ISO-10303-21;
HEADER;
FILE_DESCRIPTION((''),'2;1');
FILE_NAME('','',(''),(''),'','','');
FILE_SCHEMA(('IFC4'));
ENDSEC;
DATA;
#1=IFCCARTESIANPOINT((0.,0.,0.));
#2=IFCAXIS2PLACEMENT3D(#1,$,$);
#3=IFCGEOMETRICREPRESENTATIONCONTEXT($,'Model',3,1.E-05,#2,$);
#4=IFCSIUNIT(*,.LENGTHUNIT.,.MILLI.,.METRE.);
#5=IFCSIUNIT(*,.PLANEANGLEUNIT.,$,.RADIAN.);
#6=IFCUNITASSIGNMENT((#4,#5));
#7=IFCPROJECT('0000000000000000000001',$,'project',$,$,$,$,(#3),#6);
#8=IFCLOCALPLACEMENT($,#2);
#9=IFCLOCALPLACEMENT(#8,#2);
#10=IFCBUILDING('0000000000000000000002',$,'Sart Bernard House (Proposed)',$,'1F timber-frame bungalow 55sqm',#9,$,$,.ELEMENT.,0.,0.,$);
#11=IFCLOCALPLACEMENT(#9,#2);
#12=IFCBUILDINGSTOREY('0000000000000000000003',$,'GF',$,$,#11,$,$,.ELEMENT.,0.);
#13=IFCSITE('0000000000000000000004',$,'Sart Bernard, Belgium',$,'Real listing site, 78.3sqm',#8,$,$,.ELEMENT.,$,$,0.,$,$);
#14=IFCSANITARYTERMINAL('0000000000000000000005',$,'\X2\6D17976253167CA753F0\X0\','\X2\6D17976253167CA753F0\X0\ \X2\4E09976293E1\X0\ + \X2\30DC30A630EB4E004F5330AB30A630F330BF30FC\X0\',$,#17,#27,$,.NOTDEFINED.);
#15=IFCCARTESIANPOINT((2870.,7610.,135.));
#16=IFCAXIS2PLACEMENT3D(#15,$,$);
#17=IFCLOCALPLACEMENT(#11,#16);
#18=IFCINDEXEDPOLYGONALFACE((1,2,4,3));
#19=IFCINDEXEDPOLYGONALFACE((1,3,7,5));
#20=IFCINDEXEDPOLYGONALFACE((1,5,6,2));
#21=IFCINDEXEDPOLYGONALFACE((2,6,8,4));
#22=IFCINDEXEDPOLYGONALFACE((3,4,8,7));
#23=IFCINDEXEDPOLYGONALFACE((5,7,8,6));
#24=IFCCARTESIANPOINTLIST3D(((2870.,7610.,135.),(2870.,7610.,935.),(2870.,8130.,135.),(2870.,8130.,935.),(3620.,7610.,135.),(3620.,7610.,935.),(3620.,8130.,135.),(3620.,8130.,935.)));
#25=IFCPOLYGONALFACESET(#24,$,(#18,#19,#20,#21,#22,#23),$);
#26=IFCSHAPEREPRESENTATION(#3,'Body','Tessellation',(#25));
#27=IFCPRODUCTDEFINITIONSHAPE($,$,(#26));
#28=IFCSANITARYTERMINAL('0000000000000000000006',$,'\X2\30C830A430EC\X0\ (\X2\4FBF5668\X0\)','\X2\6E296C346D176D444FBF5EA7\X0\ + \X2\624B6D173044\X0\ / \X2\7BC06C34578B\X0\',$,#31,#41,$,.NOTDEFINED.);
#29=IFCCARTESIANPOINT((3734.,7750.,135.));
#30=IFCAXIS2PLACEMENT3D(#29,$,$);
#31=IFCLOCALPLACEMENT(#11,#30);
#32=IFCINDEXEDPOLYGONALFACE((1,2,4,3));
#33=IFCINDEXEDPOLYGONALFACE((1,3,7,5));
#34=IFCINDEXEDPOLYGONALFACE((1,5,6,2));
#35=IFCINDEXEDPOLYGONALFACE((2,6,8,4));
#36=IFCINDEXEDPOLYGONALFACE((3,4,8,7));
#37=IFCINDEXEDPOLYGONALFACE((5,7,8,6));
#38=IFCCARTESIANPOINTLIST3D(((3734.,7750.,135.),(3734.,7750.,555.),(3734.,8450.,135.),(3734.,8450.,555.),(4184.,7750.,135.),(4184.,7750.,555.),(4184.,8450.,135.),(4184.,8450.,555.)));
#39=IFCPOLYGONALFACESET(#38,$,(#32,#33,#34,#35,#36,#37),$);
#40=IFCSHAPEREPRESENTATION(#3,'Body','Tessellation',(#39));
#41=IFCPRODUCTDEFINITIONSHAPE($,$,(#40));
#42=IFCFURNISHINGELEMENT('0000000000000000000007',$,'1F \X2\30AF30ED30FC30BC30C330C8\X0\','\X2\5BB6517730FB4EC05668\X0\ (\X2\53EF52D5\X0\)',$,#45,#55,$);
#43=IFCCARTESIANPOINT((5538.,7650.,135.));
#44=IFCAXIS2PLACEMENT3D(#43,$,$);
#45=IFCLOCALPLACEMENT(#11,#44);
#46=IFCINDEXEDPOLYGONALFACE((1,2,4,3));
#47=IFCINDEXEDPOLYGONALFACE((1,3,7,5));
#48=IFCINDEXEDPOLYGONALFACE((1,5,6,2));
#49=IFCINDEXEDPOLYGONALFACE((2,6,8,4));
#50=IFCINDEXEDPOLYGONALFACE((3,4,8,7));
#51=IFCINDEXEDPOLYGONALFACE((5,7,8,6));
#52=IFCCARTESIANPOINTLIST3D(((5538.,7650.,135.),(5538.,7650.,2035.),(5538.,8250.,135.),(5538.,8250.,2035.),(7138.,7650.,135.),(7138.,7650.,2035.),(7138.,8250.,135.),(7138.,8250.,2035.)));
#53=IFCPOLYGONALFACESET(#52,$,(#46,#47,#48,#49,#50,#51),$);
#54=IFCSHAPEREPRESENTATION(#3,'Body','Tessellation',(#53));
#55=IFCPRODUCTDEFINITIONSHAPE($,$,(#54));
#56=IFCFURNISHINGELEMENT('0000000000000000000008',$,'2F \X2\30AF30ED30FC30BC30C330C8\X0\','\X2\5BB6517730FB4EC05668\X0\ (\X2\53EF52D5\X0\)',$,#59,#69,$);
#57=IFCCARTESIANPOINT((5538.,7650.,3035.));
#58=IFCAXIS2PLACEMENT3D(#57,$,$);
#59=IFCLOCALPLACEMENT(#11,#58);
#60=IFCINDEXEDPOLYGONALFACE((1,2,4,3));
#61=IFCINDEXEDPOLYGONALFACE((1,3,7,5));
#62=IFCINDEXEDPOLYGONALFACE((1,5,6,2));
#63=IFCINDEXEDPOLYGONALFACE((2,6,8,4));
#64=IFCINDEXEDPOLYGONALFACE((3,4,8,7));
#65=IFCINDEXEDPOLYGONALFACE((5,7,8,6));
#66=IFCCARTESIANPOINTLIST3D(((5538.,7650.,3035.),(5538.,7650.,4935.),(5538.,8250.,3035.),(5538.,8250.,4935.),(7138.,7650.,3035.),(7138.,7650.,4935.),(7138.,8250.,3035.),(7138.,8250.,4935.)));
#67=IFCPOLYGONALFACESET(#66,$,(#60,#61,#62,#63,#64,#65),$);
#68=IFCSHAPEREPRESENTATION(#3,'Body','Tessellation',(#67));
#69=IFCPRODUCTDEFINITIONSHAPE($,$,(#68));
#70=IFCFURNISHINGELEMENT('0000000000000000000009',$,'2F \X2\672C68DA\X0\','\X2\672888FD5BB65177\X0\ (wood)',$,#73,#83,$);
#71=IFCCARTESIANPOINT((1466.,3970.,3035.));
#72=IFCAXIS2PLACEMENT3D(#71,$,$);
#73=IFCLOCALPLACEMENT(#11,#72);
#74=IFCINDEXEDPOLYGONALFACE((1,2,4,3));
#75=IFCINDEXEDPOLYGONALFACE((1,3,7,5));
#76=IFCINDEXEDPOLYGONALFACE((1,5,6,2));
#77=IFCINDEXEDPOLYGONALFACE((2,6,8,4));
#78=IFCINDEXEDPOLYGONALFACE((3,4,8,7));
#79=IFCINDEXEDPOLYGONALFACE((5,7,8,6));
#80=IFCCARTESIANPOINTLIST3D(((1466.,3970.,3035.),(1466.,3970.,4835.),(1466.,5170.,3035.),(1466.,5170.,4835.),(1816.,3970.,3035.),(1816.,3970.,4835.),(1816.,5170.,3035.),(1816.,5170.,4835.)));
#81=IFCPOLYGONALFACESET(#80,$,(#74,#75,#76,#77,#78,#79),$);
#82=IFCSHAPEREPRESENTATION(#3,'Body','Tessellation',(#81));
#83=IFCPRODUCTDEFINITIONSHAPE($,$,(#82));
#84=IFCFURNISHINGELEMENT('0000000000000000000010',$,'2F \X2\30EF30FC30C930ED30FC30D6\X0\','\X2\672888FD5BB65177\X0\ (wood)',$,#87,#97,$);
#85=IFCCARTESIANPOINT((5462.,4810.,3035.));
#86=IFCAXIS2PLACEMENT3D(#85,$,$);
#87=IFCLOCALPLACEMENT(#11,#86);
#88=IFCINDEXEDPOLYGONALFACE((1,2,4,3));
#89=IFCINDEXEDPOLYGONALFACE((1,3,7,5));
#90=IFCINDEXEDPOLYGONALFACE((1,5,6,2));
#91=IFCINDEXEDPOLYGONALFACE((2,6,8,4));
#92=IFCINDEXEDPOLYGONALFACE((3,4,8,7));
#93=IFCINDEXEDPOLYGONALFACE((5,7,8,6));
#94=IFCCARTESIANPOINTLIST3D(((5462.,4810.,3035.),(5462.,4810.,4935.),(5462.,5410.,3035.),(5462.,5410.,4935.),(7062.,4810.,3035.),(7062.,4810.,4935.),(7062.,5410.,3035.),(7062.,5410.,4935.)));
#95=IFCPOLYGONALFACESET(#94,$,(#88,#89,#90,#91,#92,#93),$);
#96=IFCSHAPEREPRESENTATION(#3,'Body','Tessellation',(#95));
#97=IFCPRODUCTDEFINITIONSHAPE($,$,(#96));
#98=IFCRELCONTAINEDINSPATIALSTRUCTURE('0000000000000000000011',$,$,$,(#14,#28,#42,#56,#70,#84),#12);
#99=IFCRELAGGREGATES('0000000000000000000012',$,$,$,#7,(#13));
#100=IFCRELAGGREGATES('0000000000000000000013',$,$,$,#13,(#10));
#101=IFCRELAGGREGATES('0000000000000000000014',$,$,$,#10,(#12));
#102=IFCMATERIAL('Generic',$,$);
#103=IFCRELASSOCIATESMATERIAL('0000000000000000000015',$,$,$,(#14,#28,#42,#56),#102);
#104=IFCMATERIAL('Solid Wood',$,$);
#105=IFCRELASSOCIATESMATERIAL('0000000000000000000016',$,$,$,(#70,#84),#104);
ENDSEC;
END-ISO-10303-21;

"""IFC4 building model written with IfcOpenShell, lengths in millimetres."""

from ifc_helpers import new_model, si_unit, frame, frame_2d, origin, place, context, project, spatial, rectangle, extrude, material, element, save


model = new_model("IFC4")

# Units and contexts
model_context = context("Model", 3, precision=1e-05, world=origin())
ifc_project = project(units=[si_unit("LENGTHUNIT", "METRE", prefix="MILLI"), si_unit("PLANEANGLEUNIT", "RADIAN")], contexts=[model_context])

# Site, building, storey
site_placement = place(None, origin())
site = spatial("IfcSite", under=ifc_project, at=site_placement, Name="Sart Bernard, Belgium", ObjectType="Real listing site, 78.3sqm", CompositionType="ELEMENT", RefElevation=0.0)
building_placement = place(site_placement, origin())
building = spatial("IfcBuilding", under=site, at=building_placement, Name="Sart Bernard House (Proposed)", ObjectType="1F timber-frame bungalow 55sqm", CompositionType="ELEMENT", ElevationOfRefHeight=0.0, ElevationOfTerrain=0.0)
storey_placement = place(building_placement, origin())
storey = spatial("IfcBuildingStorey", under=building, at=storey_placement, Name="GF", CompositionType="ELEMENT", Elevation=0.0)

# Shared definitions
ifc_material_1 = material(Name="Solid Wood")

# Shared definitions
ifc_material_2 = material(Name="Generic")

# Sanitary terminals
sanitary_terminal_1_placement = place(storey_placement, frame((2870.0, 7610.0, 135.0)))
element("IfcSanitaryTerminal", 1, at=sanitary_terminal_1_placement, inside=storey, material=ifc_material_2, Name="洗面化粧台", Description="洗面化粧台 三面鏡 + ボウル一体カウンター", PredefinedType="NOTDEFINED", context=model_context, shape_type="SweptSolid", body=[
    extrude(rectangle(XDim=750.0, YDim=520.0, at=frame_2d((375.0, 260.0))), frame((2870.0, 7610.0, 135.0)), (0.0, 0.0, 1.0), 800.0),
])
sanitary_terminal_2_placement = place(storey_placement, frame((3734.0, 7750.0, 135.0)))
element("IfcSanitaryTerminal", 2, at=sanitary_terminal_2_placement, inside=storey, material=ifc_material_2, Name="トイレ (便器)", Description="温水洗浄便座 + 手洗い / 節水型", PredefinedType="NOTDEFINED", context=model_context, shape_type="SweptSolid", body=[
    extrude(rectangle(XDim=450.0, YDim=700.0, at=frame_2d((225.0, 350.0))), frame((3734.0, 7750.0, 135.0)), (0.0, 0.0, 1.0), 420.0),
])

# Furnishing elements
furnishing_1_placement = place(storey_placement, frame((5538.0, 7650.0, 135.0)))
element("IfcFurnishingElement", 3, at=furnishing_1_placement, inside=storey, material=ifc_material_2, Name="1F クローゼット", Description="家具・什器 (可動)", context=model_context, shape_type="SweptSolid", body=[
    extrude(rectangle(XDim=1600.0, YDim=600.0, at=frame_2d((800.0, 300.0))), frame((5538.0, 7650.0, 135.0)), (0.0, 0.0, 1.0), 1900.0),
])
furnishing_2_placement = place(storey_placement, frame((5538.0, 7650.0, 3035.0)))
element("IfcFurnishingElement", 4, at=furnishing_2_placement, inside=storey, material=ifc_material_2, Name="2F クローゼット", Description="家具・什器 (可動)", context=model_context, shape_type="SweptSolid", body=[
    extrude(rectangle(XDim=1600.0, YDim=600.0, at=frame_2d((800.0, 300.0))), frame((5538.0, 7650.0, 3035.0)), (0.0, 0.0, 1.0), 1900.0),
])
furnishing_3_placement = place(storey_placement, frame((1466.0, 3970.0, 3035.0)))
element("IfcFurnishingElement", 5, at=furnishing_3_placement, inside=storey, material=ifc_material_1, Name="2F 本棚", Description="木製家具 (wood)", context=model_context, shape_type="SweptSolid", body=[
    extrude(rectangle(XDim=350.0, YDim=1200.0, at=frame_2d((175.0, 600.0))), frame((1466.0, 3970.0, 3035.0)), (0.0, 0.0, 1.0), 1800.0),
])
furnishing_4_placement = place(storey_placement, frame((5462.0, 4810.0, 3035.0)))
element("IfcFurnishingElement", 6, at=furnishing_4_placement, inside=storey, material=ifc_material_1, Name="2F ワードローブ", Description="木製家具 (wood)", context=model_context, shape_type="SweptSolid", body=[
    extrude(rectangle(XDim=1600.0, YDim=600.0, at=frame_2d((800.0, 300.0))), frame((5462.0, 4810.0, 3035.0)), (0.0, 0.0, 1.0), 1900.0),
])

save(model, "model.ifc")
